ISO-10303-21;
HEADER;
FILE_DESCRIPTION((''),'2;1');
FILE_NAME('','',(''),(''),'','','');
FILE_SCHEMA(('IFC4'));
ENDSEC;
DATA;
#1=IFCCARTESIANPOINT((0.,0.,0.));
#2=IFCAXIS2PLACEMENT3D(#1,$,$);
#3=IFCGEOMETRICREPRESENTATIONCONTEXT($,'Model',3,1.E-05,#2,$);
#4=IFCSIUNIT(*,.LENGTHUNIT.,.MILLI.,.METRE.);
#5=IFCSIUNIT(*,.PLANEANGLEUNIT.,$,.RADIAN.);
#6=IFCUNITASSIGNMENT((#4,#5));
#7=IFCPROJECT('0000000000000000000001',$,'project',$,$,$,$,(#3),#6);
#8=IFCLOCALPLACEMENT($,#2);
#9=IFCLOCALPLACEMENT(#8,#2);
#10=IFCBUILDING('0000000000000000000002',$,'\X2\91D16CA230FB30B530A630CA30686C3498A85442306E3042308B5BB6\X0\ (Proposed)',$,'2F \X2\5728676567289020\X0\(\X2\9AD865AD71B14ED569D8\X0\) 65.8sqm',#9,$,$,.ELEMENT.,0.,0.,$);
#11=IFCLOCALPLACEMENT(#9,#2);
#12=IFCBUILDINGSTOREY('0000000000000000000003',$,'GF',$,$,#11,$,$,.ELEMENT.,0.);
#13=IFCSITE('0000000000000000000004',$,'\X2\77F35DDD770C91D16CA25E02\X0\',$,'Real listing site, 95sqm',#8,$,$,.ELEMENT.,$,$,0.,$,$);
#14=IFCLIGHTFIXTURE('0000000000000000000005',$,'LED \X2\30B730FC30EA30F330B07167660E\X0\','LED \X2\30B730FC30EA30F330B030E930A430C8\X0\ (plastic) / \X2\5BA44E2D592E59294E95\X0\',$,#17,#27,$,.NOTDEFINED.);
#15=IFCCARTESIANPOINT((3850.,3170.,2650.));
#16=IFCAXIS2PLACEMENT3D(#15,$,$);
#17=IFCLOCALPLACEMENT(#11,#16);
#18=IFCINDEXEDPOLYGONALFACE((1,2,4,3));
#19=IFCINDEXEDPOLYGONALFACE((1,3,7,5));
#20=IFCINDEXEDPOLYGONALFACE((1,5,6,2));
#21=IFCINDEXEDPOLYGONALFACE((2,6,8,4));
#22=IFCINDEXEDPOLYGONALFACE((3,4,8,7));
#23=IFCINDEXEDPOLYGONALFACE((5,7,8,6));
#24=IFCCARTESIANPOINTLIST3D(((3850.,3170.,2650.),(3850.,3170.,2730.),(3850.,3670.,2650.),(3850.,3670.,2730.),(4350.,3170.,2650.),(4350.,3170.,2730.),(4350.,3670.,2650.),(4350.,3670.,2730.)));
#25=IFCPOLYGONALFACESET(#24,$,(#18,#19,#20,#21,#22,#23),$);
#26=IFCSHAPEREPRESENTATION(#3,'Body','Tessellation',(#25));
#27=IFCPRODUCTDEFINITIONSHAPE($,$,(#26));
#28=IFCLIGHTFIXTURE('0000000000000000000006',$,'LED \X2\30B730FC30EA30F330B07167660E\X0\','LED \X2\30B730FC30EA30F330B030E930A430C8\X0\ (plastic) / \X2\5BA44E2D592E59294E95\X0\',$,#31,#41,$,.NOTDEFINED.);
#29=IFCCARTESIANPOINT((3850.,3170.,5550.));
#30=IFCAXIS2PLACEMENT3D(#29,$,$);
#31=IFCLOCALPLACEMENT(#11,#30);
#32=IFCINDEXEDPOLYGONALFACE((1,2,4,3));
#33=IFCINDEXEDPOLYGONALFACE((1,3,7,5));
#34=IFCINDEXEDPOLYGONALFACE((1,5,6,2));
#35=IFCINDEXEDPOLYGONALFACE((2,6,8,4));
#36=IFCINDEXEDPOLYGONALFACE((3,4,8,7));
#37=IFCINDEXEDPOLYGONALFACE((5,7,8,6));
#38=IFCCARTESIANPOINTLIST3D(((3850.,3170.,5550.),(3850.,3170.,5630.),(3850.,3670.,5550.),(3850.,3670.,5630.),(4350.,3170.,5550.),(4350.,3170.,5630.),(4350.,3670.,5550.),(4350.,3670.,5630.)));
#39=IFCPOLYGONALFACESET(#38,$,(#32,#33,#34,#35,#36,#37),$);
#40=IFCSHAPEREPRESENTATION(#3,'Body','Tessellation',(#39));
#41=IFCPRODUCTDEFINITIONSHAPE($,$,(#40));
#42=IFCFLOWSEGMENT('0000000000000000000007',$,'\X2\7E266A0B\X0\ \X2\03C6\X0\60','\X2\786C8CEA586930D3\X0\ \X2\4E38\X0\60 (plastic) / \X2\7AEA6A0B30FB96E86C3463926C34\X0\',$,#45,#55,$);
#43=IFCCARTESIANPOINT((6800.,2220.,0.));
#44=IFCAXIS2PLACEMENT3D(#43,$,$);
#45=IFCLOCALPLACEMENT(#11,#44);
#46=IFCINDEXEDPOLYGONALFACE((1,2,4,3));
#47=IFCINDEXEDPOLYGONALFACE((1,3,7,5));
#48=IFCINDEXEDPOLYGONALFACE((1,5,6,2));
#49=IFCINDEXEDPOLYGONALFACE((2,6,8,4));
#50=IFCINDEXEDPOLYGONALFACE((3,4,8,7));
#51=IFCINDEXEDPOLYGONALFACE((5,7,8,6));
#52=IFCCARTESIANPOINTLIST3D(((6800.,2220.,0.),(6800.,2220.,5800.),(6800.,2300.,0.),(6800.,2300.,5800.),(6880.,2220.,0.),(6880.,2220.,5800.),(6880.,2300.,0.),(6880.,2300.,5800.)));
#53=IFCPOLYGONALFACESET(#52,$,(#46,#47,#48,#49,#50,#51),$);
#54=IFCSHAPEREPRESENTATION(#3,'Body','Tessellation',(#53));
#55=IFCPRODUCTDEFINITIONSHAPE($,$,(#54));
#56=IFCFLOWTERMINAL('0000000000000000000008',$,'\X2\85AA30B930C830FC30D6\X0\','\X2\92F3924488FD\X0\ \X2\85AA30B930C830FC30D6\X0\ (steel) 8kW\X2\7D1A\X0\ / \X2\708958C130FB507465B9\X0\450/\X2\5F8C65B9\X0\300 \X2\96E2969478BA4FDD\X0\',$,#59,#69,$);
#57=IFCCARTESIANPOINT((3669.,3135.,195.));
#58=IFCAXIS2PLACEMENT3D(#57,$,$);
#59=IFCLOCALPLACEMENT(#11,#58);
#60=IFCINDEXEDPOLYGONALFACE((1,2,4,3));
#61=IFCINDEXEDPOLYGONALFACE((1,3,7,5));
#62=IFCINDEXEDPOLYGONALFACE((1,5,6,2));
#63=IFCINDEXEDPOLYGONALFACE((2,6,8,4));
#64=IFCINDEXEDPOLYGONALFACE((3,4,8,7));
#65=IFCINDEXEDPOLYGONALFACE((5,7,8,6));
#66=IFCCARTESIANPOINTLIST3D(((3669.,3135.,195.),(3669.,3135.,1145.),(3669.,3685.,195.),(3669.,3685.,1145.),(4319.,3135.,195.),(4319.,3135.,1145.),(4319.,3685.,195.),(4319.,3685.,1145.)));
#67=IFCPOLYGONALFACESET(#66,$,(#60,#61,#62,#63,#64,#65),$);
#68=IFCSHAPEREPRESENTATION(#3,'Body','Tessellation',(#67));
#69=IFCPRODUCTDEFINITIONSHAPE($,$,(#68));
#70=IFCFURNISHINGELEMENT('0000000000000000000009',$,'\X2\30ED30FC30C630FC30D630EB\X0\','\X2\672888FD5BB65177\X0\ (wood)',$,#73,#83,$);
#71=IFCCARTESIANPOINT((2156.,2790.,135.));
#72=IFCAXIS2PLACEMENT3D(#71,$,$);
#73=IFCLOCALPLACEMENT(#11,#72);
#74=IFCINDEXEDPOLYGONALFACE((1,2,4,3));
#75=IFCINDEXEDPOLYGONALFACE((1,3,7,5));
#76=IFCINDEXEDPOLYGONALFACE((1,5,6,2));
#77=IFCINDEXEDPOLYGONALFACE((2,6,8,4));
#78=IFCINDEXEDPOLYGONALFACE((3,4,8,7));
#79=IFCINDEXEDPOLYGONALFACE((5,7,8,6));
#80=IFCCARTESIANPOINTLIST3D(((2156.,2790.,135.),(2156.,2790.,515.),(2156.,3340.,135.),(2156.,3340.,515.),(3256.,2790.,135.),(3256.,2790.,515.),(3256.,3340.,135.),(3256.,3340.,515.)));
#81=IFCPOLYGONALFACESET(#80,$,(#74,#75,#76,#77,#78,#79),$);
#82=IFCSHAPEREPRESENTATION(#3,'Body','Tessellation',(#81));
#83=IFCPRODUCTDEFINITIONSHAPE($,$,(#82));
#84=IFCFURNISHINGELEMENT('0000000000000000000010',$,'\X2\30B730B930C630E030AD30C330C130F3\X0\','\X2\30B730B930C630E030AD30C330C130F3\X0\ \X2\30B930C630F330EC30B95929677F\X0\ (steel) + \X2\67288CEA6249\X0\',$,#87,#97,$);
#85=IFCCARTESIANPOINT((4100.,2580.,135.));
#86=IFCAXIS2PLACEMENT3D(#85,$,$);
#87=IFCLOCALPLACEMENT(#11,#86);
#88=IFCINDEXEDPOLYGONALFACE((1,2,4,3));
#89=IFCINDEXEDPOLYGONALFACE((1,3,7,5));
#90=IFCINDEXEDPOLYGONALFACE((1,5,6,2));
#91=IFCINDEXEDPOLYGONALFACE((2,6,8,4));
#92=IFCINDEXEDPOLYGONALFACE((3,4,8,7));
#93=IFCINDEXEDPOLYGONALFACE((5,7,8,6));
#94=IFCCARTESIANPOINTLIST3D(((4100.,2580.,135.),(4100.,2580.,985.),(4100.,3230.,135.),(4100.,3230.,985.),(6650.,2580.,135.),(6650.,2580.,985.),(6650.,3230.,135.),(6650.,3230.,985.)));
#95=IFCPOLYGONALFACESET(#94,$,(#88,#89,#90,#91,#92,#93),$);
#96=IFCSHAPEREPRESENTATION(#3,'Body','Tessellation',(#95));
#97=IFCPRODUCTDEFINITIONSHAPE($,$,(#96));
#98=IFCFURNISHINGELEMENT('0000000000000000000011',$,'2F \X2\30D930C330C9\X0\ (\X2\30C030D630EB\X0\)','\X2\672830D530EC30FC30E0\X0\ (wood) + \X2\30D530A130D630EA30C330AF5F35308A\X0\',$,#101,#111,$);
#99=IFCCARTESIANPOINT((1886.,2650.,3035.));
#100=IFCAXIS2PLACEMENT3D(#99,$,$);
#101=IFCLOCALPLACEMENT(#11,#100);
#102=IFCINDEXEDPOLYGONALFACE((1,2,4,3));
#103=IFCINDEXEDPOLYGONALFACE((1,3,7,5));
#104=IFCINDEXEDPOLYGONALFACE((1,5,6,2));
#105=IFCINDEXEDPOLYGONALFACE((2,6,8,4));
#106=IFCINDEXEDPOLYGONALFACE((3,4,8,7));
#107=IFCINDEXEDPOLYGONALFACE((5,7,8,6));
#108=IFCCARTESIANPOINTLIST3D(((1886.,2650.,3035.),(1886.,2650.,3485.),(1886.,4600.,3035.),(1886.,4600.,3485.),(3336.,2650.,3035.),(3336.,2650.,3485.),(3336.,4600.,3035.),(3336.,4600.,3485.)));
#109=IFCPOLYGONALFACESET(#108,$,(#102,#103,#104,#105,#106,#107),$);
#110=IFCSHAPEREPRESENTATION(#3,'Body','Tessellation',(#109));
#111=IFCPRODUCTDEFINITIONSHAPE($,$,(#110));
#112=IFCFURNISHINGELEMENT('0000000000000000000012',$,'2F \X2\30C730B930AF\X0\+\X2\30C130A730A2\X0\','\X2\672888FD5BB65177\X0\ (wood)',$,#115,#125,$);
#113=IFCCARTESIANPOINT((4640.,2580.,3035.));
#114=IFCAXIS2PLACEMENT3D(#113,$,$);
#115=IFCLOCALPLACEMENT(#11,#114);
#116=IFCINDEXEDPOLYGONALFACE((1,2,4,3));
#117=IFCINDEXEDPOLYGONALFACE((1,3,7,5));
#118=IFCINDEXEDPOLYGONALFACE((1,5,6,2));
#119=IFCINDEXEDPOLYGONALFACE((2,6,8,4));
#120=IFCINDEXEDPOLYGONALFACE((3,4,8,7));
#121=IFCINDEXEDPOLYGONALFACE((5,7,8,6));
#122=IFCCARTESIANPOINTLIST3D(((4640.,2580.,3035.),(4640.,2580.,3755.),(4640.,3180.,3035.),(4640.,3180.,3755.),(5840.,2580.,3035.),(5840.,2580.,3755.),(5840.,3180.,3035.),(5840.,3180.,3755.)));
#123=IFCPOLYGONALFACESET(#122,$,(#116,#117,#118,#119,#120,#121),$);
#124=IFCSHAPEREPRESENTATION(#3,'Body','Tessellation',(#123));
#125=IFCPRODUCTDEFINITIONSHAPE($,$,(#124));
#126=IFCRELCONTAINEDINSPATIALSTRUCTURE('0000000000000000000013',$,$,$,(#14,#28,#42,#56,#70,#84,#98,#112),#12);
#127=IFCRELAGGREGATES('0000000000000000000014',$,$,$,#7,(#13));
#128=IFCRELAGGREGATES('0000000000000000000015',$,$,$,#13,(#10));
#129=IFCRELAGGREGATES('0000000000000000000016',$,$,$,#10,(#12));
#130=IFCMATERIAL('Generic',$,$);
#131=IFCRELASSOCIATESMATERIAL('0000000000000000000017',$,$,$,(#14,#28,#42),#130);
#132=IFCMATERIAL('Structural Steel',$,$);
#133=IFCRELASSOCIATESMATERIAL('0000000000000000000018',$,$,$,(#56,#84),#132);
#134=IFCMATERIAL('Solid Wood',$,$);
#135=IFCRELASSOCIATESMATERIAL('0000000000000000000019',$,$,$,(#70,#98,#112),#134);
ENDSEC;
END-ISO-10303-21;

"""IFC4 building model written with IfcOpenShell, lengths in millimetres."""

from ifc_helpers import new_model, si_unit, frame, frame_2d, origin, place, context, project, spatial, rectangle, extrude, material, element, save


model = new_model("IFC4")

# Units and contexts
model_context = context("Model", 3, precision=1e-05, world=origin())
ifc_project = project(units=[si_unit("LENGTHUNIT", "METRE", prefix="MILLI"), si_unit("PLANEANGLEUNIT", "RADIAN")], contexts=[model_context])

# Site, building, storey
site_placement = place(None, origin())
site = spatial("IfcSite", under=ifc_project, at=site_placement, Name="石川県金沢市", ObjectType="Real listing site, 95sqm", CompositionType="ELEMENT", RefElevation=0.0)
building_placement = place(site_placement, origin())
building = spatial("IfcBuilding", under=site, at=building_placement, Name="金沢・サウナと水風呂のある家 (Proposed)", ObjectType="2F 在来木造(高断熱仕様) 65.8sqm", CompositionType="ELEMENT", ElevationOfRefHeight=0.0, ElevationOfTerrain=0.0)
storey_placement = place(building_placement, origin())
storey = spatial("IfcBuildingStorey", under=building, at=storey_placement, Name="GF", CompositionType="ELEMENT", Elevation=0.0)

# Shared definitions
ifc_material_1 = material(Name="Solid Wood")

# Shared definitions
ifc_material_2 = material(Name="Structural Steel")

# Shared definitions
ifc_material_3 = material(Name="Generic")

# Light fixtures
light_fixture_1_placement = place(storey_placement, frame((3850.0, 3170.0, 2650.0)))
element("IfcLightFixture", 1, at=light_fixture_1_placement, inside=storey, material=ifc_material_3, Name="LED シーリング照明", Description="LED シーリングライト (plastic) / 室中央天井", PredefinedType="NOTDEFINED", context=model_context, shape_type="SweptSolid", body=[
    extrude(rectangle(XDim=500.0, YDim=500.0, at=frame_2d((250.0, 250.0))), frame((3850.0, 3170.0, 2650.0)), (0.0, 0.0, 1.0), 80.0),
])
light_fixture_2_placement = place(storey_placement, frame((3850.0, 3170.0, 5550.0)))
element("IfcLightFixture", 2, at=light_fixture_2_placement, inside=storey, material=ifc_material_3, Name="LED シーリング照明", Description="LED シーリングライト (plastic) / 室中央天井", PredefinedType="NOTDEFINED", context=model_context, shape_type="SweptSolid", body=[
    extrude(rectangle(XDim=500.0, YDim=500.0, at=frame_2d((250.0, 250.0))), frame((3850.0, 3170.0, 5550.0)), (0.0, 0.0, 1.0), 80.0),
])

# Flow segment
flow_segment_placement = place(storey_placement, frame((6800.0, 2220.0, 0.0)))
element("IfcFlowSegment", 3, at=flow_segment_placement, inside=storey, material=ifc_material_3, Name="縦樋 φ60", Description="硬質塩ビ 丸60 (plastic) / 竪樋・雨水排水", context=model_context, shape_type="SweptSolid", body=[
    extrude(rectangle(XDim=80.0, YDim=80.0, at=frame_2d((40.0, 40.0))), frame((6800.0, 2220.0, 0.0)), (0.0, 0.0, 1.0), 5800.0),
])

# Flow terminal
flow_terminal_1_placement = place(storey_placement, frame((3669.0, 3135.0, 195.0)))
element("IfcFlowTerminal", 4, at=flow_terminal_1_placement, inside=storey, material=ifc_material_2, Name="薪ストーブ", Description="鋳鉄製 薪ストーブ (steel) 8kW級 / 炉壁・側方450/後方300 離隔確保", context=model_context, shape_type="SweptSolid", body=[
    extrude(rectangle(XDim=650.0, YDim=550.0, at=frame_2d((325.0, 275.0))), frame((3669.0, 3135.0, 195.0)), (0.0, 0.0, 1.0), 950.0),
])

# Furnishing elements
furnishing_1_placement = place(storey_placement, frame((2156.0, 2790.0, 135.0)))
element("IfcFurnishingElement", 5, at=furnishing_1_placement, inside=storey, material=ifc_material_1, Name="ローテーブル", Description="木製家具 (wood)", context=model_context, shape_type="SweptSolid", body=[
    extrude(rectangle(XDim=1100.0, YDim=550.0, at=frame_2d((550.0, 275.0))), frame((2156.0, 2790.0, 135.0)), (0.0, 0.0, 1.0), 380.0),
])
furnishing_2_placement = place(storey_placement, frame((4100.0, 2580.0, 135.0)))
element("IfcFurnishingElement", 6, at=furnishing_2_placement, inside=storey, material=ifc_material_2, Name="システムキッチン", Description="システムキッチン ステンレス天板 (steel) + 木質扉", context=model_context, shape_type="SweptSolid", body=[
    extrude(rectangle(XDim=2550.0, YDim=650.0, at=frame_2d((1275.0, 325.0))), frame((4100.0, 2580.0, 135.0)), (0.0, 0.0, 1.0), 850.0),
])
furnishing_3_placement = place(storey_placement, frame((1886.0, 2650.0, 3035.0)))
element("IfcFurnishingElement", 7, at=furnishing_3_placement, inside=storey, material=ifc_material_1, Name="2F ベッド (ダブル)", Description="木フレーム (wood) + ファブリック張り", context=model_context, shape_type="SweptSolid", body=[
    extrude(rectangle(XDim=1450.0, YDim=1950.0, at=frame_2d((725.0, 975.0))), frame((1886.0, 2650.0, 3035.0)), (0.0, 0.0, 1.0), 450.0),
])
furnishing_4_placement = place(storey_placement, frame((4640.0, 2580.0, 3035.0)))
element("IfcFurnishingElement", 8, at=furnishing_4_placement, inside=storey, material=ifc_material_1, Name="2F デスク+チェア", Description="木製家具 (wood)", context=model_context, shape_type="SweptSolid", body=[
    extrude(rectangle(XDim=1200.0, YDim=600.0, at=frame_2d((600.0, 300.0))), frame((4640.0, 2580.0, 3035.0)), (0.0, 0.0, 1.0), 720.0),
])

save(model, "model.ifc")
